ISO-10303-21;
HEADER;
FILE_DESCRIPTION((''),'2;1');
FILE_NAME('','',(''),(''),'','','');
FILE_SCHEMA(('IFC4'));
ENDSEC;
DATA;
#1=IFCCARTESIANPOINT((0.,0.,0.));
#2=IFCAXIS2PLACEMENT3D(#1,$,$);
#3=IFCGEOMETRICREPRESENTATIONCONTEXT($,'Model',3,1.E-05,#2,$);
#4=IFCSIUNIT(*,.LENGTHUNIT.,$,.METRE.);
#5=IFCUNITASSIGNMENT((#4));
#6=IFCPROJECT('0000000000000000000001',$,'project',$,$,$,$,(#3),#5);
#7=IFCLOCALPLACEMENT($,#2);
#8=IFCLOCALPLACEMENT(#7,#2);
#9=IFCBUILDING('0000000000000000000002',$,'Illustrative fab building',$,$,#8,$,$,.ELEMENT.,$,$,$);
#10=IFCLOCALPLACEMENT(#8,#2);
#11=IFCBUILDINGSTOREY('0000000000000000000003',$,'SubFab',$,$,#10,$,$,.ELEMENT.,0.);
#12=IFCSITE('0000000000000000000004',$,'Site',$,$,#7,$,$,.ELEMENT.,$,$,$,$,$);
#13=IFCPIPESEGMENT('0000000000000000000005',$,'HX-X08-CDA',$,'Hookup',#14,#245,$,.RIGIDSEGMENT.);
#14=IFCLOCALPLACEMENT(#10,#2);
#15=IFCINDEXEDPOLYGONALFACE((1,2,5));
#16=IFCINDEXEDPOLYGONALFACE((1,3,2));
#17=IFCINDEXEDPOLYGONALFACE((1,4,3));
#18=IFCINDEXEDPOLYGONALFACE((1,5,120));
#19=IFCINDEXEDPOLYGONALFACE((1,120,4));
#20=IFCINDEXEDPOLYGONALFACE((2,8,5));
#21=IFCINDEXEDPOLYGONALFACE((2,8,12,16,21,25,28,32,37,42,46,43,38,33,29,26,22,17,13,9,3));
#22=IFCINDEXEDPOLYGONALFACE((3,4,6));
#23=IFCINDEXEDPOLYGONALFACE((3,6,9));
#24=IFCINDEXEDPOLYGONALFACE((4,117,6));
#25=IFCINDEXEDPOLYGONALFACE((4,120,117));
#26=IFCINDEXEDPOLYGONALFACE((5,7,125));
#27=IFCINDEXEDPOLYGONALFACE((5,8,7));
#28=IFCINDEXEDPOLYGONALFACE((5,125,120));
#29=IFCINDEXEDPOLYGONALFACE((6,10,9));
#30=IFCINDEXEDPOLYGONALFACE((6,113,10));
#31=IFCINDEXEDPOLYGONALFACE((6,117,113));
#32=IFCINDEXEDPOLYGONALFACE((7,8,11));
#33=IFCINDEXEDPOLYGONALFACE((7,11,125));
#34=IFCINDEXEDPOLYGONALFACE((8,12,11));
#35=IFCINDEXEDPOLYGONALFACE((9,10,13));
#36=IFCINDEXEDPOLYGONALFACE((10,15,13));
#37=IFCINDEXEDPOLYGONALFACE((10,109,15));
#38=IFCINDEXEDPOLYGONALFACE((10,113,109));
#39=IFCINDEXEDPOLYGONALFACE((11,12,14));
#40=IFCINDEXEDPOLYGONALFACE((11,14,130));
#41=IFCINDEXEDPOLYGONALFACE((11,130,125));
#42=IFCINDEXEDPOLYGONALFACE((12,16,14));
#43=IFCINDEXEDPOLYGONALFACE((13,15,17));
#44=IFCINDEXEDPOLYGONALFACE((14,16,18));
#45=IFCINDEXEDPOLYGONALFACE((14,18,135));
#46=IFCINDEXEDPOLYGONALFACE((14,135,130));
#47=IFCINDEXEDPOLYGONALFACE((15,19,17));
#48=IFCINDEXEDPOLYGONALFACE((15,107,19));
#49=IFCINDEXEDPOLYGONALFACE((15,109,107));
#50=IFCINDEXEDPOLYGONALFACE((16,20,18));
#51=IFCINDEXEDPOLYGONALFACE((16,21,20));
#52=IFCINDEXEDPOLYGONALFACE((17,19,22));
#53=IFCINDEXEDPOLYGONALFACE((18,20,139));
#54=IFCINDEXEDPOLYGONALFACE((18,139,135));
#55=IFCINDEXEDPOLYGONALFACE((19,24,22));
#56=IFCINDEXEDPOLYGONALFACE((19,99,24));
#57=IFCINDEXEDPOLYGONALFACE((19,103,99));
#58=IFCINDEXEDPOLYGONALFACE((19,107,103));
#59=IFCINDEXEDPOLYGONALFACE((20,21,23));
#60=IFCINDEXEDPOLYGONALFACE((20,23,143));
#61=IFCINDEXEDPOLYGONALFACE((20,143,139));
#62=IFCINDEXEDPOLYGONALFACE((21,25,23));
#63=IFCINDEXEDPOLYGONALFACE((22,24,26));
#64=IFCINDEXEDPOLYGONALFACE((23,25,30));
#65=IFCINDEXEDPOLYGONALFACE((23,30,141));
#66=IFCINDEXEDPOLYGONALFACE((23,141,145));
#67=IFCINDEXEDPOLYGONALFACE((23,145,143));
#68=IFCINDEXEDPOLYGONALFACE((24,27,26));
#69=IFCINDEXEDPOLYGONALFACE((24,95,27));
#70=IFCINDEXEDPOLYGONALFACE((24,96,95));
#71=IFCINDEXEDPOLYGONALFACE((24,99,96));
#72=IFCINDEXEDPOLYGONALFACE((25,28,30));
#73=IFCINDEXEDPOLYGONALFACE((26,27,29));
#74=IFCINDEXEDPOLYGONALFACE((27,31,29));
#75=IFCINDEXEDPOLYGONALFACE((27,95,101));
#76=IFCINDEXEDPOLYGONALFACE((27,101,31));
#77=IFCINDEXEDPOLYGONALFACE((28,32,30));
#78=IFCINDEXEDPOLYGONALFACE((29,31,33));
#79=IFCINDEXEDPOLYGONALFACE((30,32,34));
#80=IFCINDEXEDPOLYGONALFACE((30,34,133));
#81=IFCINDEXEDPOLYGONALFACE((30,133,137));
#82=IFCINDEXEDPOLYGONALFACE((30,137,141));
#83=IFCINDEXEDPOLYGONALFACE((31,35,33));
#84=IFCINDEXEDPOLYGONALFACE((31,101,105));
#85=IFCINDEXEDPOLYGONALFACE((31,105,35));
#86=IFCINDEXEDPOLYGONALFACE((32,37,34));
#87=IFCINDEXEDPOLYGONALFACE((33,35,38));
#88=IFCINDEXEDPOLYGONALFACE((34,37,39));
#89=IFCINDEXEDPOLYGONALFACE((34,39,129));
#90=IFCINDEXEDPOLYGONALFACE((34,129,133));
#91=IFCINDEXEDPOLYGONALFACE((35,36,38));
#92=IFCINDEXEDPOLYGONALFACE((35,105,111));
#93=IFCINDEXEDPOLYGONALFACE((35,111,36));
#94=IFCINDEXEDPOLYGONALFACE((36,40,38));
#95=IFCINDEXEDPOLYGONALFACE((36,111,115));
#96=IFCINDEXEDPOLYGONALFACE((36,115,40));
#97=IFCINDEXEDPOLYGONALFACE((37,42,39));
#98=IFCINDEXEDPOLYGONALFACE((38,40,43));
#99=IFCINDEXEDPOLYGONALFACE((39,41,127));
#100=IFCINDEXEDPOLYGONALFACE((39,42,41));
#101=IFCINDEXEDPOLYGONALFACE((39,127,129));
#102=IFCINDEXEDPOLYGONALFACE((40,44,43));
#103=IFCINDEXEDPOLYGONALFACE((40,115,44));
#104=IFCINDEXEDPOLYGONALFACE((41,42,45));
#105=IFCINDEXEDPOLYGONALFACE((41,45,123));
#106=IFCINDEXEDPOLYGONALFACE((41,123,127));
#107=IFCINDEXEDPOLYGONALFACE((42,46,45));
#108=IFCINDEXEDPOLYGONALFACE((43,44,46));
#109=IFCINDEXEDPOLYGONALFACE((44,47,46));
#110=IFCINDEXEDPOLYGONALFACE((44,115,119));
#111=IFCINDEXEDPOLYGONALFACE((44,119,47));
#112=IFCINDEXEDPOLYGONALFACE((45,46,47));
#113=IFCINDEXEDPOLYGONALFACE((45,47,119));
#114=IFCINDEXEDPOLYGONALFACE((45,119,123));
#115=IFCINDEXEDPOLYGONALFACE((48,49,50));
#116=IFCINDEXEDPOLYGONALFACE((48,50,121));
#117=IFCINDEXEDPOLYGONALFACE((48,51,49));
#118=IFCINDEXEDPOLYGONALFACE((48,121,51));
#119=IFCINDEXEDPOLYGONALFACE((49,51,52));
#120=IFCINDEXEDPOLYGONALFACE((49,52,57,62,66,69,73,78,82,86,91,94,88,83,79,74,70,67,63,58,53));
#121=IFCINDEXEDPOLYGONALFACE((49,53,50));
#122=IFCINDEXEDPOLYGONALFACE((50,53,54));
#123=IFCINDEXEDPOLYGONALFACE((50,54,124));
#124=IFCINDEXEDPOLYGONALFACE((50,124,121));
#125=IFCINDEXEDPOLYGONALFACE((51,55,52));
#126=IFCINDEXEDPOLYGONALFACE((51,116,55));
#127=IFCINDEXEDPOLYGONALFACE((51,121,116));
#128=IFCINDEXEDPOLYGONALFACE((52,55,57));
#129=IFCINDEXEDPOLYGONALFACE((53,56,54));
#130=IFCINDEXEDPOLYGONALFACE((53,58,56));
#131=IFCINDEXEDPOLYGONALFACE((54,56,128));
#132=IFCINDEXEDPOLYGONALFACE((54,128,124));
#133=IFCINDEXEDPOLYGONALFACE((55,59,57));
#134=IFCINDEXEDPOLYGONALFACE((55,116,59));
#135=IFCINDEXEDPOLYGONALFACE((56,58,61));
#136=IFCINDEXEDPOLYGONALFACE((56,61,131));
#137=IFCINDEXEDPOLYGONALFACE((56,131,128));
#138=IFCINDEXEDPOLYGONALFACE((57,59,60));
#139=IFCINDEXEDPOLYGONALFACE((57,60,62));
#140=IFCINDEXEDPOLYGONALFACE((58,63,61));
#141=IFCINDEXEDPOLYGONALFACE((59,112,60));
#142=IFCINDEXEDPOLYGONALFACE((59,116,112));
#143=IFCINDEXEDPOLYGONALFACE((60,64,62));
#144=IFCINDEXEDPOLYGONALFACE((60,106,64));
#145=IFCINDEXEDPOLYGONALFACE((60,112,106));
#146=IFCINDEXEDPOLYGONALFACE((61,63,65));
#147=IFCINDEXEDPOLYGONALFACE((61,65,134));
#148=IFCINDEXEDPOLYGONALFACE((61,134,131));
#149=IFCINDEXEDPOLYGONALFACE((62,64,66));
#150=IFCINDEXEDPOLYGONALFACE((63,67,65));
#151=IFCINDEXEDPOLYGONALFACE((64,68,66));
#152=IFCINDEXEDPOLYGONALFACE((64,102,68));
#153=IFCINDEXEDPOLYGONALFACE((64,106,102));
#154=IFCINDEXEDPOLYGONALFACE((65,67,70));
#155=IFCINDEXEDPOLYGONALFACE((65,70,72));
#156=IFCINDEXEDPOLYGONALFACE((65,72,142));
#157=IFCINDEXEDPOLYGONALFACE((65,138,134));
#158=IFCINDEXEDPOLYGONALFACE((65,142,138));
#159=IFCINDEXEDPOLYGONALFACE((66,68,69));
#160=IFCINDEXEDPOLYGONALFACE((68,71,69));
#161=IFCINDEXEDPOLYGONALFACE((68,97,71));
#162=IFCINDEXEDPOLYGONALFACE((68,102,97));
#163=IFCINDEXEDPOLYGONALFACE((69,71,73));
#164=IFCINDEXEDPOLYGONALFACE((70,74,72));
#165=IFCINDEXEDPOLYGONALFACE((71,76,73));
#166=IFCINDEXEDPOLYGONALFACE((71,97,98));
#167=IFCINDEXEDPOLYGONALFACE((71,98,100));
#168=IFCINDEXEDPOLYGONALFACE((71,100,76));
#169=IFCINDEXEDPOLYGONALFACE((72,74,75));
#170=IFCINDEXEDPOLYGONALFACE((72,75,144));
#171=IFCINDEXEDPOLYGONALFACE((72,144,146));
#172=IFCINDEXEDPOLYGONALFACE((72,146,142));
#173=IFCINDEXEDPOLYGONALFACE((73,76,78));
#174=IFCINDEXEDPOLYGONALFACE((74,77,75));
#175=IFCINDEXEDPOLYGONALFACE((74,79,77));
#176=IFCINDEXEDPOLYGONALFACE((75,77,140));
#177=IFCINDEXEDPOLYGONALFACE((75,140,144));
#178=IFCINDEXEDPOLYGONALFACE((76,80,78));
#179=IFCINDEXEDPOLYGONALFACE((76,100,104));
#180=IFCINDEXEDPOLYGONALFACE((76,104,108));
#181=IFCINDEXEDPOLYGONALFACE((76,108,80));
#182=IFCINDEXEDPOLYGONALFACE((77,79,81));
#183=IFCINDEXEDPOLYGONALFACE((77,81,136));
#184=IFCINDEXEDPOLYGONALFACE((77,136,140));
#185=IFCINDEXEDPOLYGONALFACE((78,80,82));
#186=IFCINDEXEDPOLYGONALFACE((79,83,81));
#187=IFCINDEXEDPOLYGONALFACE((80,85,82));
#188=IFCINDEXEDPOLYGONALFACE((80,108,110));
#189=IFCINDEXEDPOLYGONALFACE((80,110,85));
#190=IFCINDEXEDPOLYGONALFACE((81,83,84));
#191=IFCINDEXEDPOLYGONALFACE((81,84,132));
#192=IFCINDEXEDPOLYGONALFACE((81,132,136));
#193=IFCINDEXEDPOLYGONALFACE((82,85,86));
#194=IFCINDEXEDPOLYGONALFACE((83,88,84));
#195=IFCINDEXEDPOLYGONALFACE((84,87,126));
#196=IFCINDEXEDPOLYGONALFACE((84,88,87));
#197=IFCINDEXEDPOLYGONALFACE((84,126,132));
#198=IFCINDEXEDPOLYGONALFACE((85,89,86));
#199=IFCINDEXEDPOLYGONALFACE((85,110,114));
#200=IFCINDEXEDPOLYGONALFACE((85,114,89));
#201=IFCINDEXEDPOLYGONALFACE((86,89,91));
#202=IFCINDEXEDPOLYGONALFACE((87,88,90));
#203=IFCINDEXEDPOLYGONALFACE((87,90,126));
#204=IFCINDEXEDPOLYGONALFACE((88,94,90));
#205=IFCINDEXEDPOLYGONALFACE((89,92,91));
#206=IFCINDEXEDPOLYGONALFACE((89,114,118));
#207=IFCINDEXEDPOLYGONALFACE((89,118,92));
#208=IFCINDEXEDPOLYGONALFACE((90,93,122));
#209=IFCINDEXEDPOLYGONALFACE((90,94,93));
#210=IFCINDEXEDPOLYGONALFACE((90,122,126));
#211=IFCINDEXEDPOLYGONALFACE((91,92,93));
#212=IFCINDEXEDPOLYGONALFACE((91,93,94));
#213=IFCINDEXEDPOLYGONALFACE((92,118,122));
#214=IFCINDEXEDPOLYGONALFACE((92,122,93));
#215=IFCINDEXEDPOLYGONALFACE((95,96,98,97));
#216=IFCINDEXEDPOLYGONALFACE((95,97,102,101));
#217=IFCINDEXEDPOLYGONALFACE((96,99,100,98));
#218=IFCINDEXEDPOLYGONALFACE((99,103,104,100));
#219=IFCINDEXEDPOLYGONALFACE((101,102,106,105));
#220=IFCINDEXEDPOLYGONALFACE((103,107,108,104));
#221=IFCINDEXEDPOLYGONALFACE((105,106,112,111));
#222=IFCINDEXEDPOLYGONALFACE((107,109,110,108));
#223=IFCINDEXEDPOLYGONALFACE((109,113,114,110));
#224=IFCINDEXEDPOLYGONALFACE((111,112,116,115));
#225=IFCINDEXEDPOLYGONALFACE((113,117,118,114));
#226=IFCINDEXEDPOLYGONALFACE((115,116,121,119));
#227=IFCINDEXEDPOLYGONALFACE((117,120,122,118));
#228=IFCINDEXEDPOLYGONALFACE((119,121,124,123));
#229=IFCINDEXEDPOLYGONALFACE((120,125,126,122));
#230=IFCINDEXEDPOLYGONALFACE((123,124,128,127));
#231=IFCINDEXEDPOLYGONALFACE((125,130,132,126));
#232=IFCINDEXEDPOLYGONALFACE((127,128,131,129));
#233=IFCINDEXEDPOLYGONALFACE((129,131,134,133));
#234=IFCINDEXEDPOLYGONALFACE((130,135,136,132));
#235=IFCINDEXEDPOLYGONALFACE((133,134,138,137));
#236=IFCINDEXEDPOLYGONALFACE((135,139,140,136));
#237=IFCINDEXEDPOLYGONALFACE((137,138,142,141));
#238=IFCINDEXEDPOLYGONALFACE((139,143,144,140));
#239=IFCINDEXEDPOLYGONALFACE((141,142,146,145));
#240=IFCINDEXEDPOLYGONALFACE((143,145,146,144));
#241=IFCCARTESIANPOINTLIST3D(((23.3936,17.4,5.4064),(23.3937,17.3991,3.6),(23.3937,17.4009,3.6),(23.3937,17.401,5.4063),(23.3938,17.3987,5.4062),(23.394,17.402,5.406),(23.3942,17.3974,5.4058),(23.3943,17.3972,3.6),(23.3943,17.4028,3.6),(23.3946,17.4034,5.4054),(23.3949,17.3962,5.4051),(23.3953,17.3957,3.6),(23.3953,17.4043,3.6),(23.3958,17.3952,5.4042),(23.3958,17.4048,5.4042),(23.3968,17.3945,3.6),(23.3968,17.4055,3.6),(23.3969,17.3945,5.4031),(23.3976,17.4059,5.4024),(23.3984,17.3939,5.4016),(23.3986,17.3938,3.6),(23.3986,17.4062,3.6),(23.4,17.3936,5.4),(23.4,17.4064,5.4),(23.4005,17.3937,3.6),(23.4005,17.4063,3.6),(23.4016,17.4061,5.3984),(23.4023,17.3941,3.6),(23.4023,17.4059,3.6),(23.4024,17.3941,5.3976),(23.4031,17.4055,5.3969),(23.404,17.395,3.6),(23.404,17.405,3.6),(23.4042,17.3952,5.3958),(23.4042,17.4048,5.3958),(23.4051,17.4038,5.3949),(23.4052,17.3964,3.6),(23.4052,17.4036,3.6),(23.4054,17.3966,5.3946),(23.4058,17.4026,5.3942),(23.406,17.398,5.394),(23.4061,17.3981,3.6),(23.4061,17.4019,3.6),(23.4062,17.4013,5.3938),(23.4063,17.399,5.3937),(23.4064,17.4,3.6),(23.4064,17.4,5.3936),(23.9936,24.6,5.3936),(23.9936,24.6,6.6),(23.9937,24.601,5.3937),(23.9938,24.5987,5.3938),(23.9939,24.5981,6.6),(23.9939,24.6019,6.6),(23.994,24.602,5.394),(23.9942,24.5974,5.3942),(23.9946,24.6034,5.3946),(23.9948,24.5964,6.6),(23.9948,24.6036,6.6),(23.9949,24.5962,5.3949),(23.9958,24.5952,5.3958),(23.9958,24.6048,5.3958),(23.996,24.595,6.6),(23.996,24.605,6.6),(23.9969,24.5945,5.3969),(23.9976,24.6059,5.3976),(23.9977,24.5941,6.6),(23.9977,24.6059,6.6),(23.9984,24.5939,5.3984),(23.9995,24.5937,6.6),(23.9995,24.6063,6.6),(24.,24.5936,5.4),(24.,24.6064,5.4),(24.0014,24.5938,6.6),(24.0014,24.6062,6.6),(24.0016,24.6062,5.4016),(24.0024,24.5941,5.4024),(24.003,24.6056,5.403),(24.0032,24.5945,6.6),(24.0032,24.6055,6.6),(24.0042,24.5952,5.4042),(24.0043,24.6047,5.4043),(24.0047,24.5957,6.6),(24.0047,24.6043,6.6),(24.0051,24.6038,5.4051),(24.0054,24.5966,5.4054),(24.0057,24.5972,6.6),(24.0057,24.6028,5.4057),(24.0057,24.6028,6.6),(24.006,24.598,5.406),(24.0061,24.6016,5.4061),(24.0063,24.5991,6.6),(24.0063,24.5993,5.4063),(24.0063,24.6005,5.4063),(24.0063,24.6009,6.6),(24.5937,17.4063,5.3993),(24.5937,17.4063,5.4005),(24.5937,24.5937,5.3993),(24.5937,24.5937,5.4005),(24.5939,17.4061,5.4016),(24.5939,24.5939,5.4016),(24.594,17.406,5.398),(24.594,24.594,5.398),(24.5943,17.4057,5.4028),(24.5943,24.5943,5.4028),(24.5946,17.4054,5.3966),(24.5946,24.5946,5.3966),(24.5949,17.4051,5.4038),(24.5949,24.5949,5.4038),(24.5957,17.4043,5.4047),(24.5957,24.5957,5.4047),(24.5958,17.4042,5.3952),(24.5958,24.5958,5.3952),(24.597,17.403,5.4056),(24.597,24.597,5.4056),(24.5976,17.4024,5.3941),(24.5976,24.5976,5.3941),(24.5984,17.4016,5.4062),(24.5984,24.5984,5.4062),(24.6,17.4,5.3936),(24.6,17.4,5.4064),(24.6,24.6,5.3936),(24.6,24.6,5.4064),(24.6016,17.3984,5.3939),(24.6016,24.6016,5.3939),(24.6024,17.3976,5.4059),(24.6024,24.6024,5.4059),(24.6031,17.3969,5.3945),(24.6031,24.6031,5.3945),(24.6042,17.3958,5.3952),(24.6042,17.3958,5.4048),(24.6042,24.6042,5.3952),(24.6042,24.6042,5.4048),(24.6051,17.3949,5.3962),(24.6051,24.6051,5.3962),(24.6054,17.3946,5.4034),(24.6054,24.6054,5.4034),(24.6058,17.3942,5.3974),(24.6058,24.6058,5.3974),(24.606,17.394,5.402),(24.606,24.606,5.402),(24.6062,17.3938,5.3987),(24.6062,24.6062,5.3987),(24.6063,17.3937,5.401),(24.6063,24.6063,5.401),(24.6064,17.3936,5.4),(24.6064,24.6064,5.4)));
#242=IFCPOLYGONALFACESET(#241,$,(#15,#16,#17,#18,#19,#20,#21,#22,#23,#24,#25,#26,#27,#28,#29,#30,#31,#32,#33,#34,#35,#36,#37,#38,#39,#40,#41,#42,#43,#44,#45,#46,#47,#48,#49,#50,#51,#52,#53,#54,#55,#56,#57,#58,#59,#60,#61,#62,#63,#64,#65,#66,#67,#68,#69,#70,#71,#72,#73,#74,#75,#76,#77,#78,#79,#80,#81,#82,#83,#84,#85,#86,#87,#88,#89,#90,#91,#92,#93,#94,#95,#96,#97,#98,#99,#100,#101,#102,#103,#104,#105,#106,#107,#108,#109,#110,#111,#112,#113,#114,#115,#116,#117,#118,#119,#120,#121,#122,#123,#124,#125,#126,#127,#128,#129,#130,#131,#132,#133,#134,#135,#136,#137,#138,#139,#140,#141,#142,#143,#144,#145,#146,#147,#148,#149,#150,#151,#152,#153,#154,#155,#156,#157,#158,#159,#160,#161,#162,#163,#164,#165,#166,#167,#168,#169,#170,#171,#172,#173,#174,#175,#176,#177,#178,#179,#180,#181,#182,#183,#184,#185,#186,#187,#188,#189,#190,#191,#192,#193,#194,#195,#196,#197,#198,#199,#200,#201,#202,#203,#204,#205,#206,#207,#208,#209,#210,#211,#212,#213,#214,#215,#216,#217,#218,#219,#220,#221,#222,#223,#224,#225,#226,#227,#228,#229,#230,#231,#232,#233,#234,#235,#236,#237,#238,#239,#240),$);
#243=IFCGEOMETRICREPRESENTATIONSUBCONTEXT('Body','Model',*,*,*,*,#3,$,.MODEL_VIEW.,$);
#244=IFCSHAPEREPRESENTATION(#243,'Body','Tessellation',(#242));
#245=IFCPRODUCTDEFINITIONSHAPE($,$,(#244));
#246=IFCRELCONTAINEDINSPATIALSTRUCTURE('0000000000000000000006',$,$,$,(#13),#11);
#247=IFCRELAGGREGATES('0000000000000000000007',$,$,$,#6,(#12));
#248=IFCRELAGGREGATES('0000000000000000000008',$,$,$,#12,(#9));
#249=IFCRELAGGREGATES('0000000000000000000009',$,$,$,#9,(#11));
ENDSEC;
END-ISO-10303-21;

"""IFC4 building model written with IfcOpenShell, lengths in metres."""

from ifc_helpers import new_model, entity, si_unit, origin, place, context, subcontext, project, spatial, element, save


model = new_model("IFC4")

# Units and contexts
model_context = context("Model", 3, precision=1e-05, world=origin())
body_context = subcontext(model_context, "Body", "Model", "MODEL_VIEW")
ifc_project = project(units=[si_unit("LENGTHUNIT", "METRE")], contexts=[model_context])

# Site, building, storey
site_placement = place(None, origin())
site = spatial("IfcSite", under=ifc_project, at=site_placement, Name="Site", CompositionType="ELEMENT")
building_placement = place(site_placement, origin())
building = spatial("IfcBuilding", under=site, at=building_placement, Name="Illustrative fab building", CompositionType="ELEMENT")
storey_placement = place(building_placement, origin())
storey = spatial("IfcBuildingStorey", under=building, at=storey_placement, Name="SubFab", CompositionType="ELEMENT", Elevation=0.0)

# Pipe segment
pipe_segment_1_placement = place(storey_placement, origin())
element("IfcPipeSegment", 1, at=pipe_segment_1_placement, inside=storey, Name="HX-X08-CDA", ObjectType="Hookup", PredefinedType="RIGIDSEGMENT", context=body_context, shape_type="AdvancedSweptSolid", body=[
    entity("IfcSweptDiskSolid", entity("IfcPolyline", [entity("IfcCartesianPoint", [23.4, 17.4, 3.6]), entity("IfcCartesianPoint", [23.4, 17.4, 5.4]), entity("IfcCartesianPoint", [24.6, 17.4, 5.4]), entity("IfcCartesianPoint", [24.6, 24.6, 5.4]), entity("IfcCartesianPoint", [24.0, 24.6, 5.4]), entity("IfcCartesianPoint", [24.0, 24.6, 6.6])]), 0.0063),
])

save(model, "model.ifc")
